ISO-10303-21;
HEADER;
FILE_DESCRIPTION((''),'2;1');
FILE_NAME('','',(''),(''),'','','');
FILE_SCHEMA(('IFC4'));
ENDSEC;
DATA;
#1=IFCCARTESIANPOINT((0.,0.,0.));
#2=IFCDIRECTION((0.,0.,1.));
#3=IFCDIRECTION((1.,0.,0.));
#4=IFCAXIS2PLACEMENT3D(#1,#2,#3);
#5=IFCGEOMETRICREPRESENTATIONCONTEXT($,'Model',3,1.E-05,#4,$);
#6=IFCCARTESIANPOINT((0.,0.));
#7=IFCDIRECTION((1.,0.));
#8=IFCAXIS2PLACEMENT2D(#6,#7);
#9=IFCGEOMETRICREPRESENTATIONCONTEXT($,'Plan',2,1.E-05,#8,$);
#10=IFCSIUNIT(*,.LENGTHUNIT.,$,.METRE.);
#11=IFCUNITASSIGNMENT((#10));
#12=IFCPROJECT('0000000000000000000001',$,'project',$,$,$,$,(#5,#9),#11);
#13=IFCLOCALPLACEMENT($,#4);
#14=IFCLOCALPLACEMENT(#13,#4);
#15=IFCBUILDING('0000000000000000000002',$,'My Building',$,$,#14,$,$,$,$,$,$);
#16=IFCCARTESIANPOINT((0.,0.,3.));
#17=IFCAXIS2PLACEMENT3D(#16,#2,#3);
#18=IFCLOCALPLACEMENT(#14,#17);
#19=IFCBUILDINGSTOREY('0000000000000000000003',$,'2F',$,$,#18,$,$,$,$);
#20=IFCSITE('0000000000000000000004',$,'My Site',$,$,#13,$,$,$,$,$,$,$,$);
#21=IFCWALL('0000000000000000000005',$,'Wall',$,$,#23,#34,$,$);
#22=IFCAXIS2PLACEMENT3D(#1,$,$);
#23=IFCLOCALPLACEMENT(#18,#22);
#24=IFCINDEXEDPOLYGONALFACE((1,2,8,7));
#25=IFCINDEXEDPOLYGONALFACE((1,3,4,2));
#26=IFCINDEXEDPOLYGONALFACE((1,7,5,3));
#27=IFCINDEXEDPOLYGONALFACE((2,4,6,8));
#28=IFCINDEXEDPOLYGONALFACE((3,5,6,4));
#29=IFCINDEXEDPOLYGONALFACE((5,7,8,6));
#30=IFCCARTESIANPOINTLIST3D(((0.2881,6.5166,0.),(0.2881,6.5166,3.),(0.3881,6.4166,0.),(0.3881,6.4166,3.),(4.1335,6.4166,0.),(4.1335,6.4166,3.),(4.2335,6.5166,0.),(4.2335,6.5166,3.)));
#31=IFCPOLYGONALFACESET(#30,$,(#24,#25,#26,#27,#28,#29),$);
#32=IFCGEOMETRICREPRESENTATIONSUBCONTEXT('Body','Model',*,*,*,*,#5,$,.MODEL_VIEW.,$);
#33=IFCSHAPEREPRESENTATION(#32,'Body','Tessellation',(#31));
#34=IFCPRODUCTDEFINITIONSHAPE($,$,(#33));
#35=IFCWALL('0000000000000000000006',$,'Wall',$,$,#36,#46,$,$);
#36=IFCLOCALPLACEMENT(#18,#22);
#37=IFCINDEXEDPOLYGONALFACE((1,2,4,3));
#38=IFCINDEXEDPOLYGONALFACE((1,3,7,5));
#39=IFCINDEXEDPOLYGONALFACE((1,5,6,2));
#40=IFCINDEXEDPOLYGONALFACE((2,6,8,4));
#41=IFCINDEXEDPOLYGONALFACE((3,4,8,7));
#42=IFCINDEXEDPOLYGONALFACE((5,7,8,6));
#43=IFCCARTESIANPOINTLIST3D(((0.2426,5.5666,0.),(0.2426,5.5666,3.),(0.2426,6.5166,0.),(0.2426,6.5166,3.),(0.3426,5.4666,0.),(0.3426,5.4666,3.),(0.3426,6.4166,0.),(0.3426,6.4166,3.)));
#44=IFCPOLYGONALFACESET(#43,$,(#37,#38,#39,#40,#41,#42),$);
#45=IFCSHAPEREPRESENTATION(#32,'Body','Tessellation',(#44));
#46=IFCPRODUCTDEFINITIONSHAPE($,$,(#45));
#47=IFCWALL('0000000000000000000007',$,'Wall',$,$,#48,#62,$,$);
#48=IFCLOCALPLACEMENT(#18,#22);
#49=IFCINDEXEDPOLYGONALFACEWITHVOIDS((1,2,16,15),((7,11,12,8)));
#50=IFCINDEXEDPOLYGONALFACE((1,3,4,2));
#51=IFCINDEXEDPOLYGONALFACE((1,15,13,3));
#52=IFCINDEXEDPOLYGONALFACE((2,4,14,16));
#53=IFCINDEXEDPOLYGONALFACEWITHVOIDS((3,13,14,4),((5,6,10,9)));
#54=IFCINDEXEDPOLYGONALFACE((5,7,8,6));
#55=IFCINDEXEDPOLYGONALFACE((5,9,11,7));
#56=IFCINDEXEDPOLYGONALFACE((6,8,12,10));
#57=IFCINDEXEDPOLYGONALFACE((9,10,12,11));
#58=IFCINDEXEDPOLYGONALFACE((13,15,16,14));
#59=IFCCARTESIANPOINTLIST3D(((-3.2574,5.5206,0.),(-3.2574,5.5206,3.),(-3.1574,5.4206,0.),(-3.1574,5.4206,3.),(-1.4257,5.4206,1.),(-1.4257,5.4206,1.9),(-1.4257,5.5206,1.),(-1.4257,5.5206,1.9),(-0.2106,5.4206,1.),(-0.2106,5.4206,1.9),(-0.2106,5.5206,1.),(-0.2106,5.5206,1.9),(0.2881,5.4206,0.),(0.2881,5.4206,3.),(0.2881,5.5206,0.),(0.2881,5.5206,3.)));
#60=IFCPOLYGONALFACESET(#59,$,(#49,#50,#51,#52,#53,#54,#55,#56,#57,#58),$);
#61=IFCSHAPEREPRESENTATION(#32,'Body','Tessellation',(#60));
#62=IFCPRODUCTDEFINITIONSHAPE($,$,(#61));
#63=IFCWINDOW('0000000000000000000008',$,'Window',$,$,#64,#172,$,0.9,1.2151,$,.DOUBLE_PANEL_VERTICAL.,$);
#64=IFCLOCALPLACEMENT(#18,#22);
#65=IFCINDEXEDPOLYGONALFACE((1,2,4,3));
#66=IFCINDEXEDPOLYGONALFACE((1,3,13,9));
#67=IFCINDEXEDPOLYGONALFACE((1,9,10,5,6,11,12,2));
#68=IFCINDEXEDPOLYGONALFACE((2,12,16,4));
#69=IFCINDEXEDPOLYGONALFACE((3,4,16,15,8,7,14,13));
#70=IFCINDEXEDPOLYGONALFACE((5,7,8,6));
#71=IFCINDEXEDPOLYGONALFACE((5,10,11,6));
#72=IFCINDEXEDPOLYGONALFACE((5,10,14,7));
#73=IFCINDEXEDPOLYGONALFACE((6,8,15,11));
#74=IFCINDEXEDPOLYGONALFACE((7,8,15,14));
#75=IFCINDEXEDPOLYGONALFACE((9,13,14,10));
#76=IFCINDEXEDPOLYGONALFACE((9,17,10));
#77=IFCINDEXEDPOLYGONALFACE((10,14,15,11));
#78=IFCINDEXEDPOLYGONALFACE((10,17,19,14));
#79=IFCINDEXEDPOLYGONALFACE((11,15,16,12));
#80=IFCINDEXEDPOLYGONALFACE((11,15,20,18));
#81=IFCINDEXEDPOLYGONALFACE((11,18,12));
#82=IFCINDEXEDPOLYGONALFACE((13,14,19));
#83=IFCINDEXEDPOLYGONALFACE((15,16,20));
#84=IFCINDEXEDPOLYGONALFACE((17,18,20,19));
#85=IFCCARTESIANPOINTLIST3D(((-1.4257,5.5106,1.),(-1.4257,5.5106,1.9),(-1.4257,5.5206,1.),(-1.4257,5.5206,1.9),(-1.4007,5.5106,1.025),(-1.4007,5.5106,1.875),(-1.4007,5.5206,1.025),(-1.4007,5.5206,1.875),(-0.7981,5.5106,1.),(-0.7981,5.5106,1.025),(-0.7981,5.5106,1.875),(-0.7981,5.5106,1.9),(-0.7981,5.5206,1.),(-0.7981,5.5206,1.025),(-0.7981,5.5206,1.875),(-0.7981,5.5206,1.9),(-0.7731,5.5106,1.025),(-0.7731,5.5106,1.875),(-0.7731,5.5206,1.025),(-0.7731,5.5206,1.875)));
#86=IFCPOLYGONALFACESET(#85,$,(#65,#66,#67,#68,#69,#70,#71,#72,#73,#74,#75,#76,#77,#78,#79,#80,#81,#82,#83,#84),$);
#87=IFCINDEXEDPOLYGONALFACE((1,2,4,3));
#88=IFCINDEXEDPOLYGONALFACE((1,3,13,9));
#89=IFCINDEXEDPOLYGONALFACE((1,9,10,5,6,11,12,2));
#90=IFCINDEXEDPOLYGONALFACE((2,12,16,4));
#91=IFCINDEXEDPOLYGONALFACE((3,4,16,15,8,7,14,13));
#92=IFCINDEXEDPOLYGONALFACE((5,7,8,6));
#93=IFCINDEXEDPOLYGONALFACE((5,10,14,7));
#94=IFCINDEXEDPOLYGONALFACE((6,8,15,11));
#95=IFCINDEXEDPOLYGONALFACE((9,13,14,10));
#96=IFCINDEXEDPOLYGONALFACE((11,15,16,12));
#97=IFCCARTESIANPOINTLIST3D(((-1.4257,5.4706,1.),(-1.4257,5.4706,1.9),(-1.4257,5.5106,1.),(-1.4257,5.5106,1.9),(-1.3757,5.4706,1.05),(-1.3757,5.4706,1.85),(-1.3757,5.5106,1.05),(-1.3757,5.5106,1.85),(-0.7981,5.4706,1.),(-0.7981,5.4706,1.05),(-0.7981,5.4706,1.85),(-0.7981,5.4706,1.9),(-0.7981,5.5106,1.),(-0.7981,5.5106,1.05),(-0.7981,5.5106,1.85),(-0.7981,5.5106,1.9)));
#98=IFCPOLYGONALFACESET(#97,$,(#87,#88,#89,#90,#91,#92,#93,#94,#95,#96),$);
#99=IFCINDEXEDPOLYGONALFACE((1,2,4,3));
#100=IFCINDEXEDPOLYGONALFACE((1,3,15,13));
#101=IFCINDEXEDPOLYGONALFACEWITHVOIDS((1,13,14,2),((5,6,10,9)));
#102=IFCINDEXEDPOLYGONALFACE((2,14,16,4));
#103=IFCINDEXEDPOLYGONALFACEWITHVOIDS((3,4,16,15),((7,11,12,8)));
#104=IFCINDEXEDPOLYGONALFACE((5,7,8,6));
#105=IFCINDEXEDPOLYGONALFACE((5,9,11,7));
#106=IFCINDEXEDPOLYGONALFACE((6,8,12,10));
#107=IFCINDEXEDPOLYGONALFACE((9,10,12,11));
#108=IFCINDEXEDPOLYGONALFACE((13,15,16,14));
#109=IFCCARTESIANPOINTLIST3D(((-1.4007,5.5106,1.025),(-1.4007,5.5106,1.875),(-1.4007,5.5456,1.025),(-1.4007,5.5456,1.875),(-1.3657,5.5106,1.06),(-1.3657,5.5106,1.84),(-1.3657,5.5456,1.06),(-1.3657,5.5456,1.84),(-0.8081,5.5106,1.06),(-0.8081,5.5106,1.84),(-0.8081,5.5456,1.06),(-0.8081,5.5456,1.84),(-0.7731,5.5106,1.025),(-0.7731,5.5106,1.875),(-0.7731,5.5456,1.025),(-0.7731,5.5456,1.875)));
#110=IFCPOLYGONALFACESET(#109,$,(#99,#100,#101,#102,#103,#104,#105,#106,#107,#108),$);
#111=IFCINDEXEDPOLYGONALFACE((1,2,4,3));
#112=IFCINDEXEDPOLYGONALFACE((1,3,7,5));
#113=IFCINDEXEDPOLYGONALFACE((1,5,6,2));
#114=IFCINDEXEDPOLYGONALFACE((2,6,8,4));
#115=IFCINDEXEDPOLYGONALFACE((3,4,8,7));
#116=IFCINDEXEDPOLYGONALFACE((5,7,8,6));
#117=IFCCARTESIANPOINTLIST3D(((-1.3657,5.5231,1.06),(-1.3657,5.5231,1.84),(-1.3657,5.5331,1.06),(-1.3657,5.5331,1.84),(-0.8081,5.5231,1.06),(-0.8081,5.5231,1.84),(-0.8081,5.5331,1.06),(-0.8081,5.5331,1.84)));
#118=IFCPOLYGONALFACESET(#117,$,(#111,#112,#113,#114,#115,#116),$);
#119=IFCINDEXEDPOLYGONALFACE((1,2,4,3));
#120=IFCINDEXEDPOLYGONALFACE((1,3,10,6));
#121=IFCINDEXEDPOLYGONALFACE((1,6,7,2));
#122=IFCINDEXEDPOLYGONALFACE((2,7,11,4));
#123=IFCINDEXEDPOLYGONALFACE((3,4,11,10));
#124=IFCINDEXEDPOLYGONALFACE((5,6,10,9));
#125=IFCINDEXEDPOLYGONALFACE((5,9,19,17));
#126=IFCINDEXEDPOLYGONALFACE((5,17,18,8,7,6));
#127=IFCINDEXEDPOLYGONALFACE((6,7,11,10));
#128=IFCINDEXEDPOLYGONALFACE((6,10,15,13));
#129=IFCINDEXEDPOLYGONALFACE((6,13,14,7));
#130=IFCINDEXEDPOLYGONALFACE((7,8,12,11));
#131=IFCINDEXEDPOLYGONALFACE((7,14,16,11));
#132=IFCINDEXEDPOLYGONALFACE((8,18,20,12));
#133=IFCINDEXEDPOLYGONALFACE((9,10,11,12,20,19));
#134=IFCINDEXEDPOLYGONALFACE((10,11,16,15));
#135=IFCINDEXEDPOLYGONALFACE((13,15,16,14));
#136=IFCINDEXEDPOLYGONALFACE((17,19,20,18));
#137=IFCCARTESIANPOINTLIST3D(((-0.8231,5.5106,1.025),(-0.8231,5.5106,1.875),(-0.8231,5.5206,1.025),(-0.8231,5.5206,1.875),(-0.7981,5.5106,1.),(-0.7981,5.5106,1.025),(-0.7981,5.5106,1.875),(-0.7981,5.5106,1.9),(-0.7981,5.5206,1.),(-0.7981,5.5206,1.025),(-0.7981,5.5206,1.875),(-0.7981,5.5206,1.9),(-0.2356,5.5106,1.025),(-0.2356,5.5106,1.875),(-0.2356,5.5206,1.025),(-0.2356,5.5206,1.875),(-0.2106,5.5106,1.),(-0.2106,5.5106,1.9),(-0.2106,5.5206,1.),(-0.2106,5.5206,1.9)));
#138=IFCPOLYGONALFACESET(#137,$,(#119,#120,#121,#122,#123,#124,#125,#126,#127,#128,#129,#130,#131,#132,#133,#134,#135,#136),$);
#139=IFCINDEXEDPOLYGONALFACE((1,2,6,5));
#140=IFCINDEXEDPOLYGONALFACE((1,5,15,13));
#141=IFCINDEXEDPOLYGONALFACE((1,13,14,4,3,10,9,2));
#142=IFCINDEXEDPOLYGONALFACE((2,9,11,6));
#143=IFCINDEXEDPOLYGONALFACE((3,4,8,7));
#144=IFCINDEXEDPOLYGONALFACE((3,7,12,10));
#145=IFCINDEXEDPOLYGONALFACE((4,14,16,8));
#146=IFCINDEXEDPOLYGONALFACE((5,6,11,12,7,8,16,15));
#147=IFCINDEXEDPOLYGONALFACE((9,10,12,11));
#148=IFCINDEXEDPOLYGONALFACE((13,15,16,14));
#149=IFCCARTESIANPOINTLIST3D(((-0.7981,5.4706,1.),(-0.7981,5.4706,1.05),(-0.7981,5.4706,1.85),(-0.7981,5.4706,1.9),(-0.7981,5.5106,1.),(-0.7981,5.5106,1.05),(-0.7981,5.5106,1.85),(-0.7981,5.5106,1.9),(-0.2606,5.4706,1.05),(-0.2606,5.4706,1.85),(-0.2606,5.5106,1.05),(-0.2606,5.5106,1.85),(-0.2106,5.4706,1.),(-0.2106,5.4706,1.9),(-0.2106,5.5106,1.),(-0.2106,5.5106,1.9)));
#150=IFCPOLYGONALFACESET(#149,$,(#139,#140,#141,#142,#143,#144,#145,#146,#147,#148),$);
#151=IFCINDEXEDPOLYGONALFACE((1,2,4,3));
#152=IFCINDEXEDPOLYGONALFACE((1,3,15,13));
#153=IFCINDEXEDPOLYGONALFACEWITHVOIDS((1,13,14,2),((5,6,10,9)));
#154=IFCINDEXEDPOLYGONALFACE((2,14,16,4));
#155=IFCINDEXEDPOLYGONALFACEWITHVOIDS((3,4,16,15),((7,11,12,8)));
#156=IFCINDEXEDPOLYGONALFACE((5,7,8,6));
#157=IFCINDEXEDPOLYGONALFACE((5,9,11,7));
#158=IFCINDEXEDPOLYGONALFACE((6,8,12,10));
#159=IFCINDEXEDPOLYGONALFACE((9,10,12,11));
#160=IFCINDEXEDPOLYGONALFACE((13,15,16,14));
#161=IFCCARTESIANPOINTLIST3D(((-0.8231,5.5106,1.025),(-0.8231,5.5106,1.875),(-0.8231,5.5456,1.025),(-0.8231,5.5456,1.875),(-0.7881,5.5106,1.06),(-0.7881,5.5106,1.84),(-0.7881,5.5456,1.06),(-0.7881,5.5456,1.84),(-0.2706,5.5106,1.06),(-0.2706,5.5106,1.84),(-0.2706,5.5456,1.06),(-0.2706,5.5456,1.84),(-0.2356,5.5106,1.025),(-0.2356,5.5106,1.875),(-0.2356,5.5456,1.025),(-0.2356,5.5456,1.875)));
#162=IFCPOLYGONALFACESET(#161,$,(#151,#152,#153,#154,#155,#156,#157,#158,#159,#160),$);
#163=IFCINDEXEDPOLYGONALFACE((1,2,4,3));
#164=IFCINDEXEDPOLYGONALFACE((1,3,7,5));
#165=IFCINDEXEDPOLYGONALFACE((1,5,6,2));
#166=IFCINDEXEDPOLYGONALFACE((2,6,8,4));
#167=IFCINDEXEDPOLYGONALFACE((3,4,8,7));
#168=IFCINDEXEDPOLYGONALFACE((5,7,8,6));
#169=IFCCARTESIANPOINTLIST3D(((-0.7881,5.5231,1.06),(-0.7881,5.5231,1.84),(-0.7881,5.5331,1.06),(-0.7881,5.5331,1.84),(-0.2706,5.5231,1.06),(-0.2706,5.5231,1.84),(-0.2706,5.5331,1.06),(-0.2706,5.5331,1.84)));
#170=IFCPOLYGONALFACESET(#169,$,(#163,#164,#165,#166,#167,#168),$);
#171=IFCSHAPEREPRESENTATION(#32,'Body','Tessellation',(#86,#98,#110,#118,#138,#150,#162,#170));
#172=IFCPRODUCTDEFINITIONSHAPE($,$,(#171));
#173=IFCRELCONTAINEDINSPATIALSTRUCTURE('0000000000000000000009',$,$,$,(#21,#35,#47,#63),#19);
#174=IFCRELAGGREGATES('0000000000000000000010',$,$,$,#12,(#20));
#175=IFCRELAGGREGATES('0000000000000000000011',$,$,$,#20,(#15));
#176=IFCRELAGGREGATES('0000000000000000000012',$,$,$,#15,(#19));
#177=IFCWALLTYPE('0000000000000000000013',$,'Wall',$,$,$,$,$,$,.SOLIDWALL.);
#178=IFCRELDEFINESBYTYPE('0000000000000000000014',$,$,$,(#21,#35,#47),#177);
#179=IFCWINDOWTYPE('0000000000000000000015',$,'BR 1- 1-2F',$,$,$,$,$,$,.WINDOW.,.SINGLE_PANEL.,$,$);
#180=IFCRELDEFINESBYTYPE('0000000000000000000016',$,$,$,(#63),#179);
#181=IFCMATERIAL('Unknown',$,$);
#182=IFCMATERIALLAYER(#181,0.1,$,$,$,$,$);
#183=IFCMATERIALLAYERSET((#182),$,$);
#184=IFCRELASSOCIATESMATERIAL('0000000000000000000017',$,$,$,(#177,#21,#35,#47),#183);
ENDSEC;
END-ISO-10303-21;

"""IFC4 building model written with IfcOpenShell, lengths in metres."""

from ifc_helpers import new_model, entity, si_unit, frame, origin_with_axes, origin_2d_with_axis, place, context, subcontext, project, spatial, line, indexed_curve, outline, extrude, shape, source, transform, mapped, material, layer, layer_set, layer_usage, type_object, type_shapes, element, fill, save


model = new_model("IFC4")

# Units and contexts
model_context = context("Model", 3, precision=1e-05, world=origin_with_axes())
plan_context = context("Plan", 2, precision=1e-05, world=origin_2d_with_axis())
body_context_1 = subcontext(model_context, "Body", "Model", "MODEL_VIEW")
body_context_2 = subcontext(plan_context, "Body", "Plan", "PLAN_VIEW")
ifc_project = project(units=[si_unit("LENGTHUNIT", "METRE")], contexts=[model_context, plan_context])

# Site, building, storey
site_placement = place(None, origin_with_axes())
site = spatial("IfcSite", under=ifc_project, at=site_placement, Name="My Site")
building_placement = place(site_placement, origin_with_axes())
building = spatial("IfcBuilding", under=site, at=building_placement, Name="My Building")
storey_placement = place(building_placement, frame((0.0, 0.0, 3.0), z_axis=(0.0, 0.0, 1.0), x_axis=(1.0, 0.0, 0.0)))
storey = spatial("IfcBuildingStorey", under=building, at=storey_placement, Name="2F")

# Walls
ifc_material = material(Name="Unknown")
ifc_layer = layer(ifc_material, 0.1)
ifc_layer_set = layer_set([ifc_layer])
ifc_layer_usage_1 = layer_usage(ifc_layer_set, "AXIS2", "POSITIVE", 0.0)
wall_type = type_object("IfcWallType", Name="Wall", PredefinedType="SOLIDWALL", material=ifc_layer_set)
wall_1_placement = place(storey_placement, frame((4.2335, 6.5166, 0.0), z_axis=(0.0, 0.0, 1.0), x_axis=(-1.0, 0.0, 0.0)))
element("IfcWall", 1, at=wall_1_placement, inside=storey, type_object=wall_type, material=ifc_layer_usage_1, Name="Wall", context=body_context_1, shape_type="SweptSolid", body=[
    extrude(outline(indexed_curve([(0.0, 0.0), (0.1, 0.1), (3.8454, 0.1), (3.9454, 0.0)], segments=[line(1, 2, 3, 4, 1)])), origin_with_axes(), (0.0, 0.0, 1.0), 3.0),
])
ifc_layer_usage_2 = layer_usage(ifc_layer_set, "AXIS2", "POSITIVE", 0.0)
wall_2_placement = place(storey_placement, frame((0.2426, 6.5166, 0.0), z_axis=(0.0, 0.0, 1.0), x_axis=(0.0, -1.0, 0.0)))
element("IfcWall", 2, at=wall_2_placement, inside=storey, type_object=wall_type, material=ifc_layer_usage_2, Name="Wall", context=body_context_1, shape_type="SweptSolid", body=[
    extrude(outline(indexed_curve([(0.0, 0.0), (0.1, 0.1), (1.05, 0.1), (0.95, 0.0)], segments=[line(1, 2, 3, 4, 1)])), origin_with_axes(), (0.0, 0.0, 1.0), 3.0),
])

# Wall, opening, window
ifc_layer_usage_3 = layer_usage(ifc_layer_set, "AXIS2", "POSITIVE", 0.0)
wall_3_placement = place(storey_placement, frame((0.3881, 5.5206, 0.0), z_axis=(0.0, 0.0, 1.0), x_axis=(-1.0, 0.0, 0.0)))
wall_3 = element("IfcWall", 3, at=wall_3_placement, inside=storey, type_object=wall_type, material=ifc_layer_usage_3, Name="Wall", context=body_context_1, shape_type="SweptSolid", body=[
    extrude(outline(indexed_curve([(0.1, 0.0), (0.1, 0.1), (3.5455, 0.1), (3.6455, 0.0)], segments=[line(1, 2, 3, 4, 1)])), origin_with_axes(), (0.0, 0.0, 1.0), 3.0),
])
shared_shape_1 = source(origin_with_axes(), body_context_1, "Body", "SweptSolid", [
    extrude(outline(indexed_curve([(0.0, 0.0), (1.2151, 0.0), (1.2151, 0.9), (0.0, 0.9)], segments=[line(1, 2, 3, 4, 1)])), frame((0.0, -0.6, 0.0), z_axis=(0.0, -1.0, 0.0), x_axis=(1.0, 0.0, 0.0)), (0.0, 0.0, -1.0), 1.2),
])
opening_1_placement = place(wall_3_placement, frame((1.8138, 0.1, 1.0), z_axis=(0.0, 0.0, 1.0), x_axis=(-1.0, 0.0, 0.0)))
opening_1 = element("IfcOpeningElement", 4, at=opening_1_placement, cuts=wall_3, PredefinedType="OPENING", context=body_context_1, shape_type="MappedRepresentation", body=[
    mapped(shared_shape_1, transform((0.0, 0.0, 0.0), x_axis=(1.0, 0.0, 0.0), y_axis=(0.0, 1.0, 0.0), z_axis=(0.0, 0.0, 1.0), scale=1.0)),
])
window_type_1 = type_object("IfcWindowType", Name="BR 1- 1-2F", PartitioningType="SINGLE_PANEL", PredefinedType="WINDOW")
shared_shape_2 = source(origin_with_axes(), body_context_1, "Body", "SweptSolid", [
    extrude(outline(indexed_curve([(0.0, 0.0), (0.6275, 0.0), (0.6275, 0.9), (0.0, 0.9)], segments=[line(1, 2, 3, 4, 1)]), holes=[indexed_curve([(0.025, 0.025), (0.6525, 0.025), (0.6525, 0.875), (0.025, 0.875)], segments=[line(1, 2, 3, 4, 1)])]), frame((0.0, 0.09, 0.0), z_axis=(0.0, -1.0, 0.0), x_axis=(1.0, 0.0, 0.0)), (0.0, 0.0, -1.0), 0.01),
    extrude(outline(indexed_curve([(0.6275, 0.0), (0.0, 0.0), (0.0, 0.9), (0.6275, 0.9), (0.6275, 0.85), (0.05, 0.85), (0.05, 0.05), (0.6275, 0.05)], segments=[line(1, 2, 3, 4, 5, 6, 7, 8, 1)])), frame((0.0, 0.05, 0.0), z_axis=(0.0, -1.0, 0.0), x_axis=(1.0, 0.0, 0.0)), (0.0, 0.0, -1.0), 0.04),
    extrude(outline(indexed_curve([(0.0, 0.0), (0.6275, 0.0), (0.6275, 0.85), (0.0, 0.85)], segments=[line(1, 2, 3, 4, 1)]), holes=[indexed_curve([(0.035, 0.035), (0.5925, 0.035), (0.5925, 0.815), (0.035, 0.815)], segments=[line(1, 2, 3, 4, 1)])]), frame((0.025, 0.09, 0.025), z_axis=(0.0, -1.0, 0.0), x_axis=(1.0, 0.0, 0.0)), (0.0, 0.0, -1.0), 0.035),
    extrude(outline(indexed_curve([(0.035, 0.035), (0.5925, 0.035), (0.5925, 0.815), (0.035, 0.815)], segments=[line(1, 2, 3, 4, 1)])), frame((0.025, 0.1025, 0.025), z_axis=(0.0, -1.0, 0.0), x_axis=(1.0, 0.0, 0.0)), (0.0, 0.0, -1.0), 0.01),
    extrude(outline(indexed_curve([(0.0, 0.0), (0.5875, 0.0), (0.5875, 0.9), (0.0, 0.9)], segments=[line(1, 2, 3, 4, 1)]), holes=[indexed_curve([(-0.025, 0.025), (0.5625, 0.025), (0.5625, 0.875), (-0.025, 0.875)], segments=[line(1, 2, 3, 4, 1)])]), frame((0.6275, 0.09, 0.0), z_axis=(0.0, -1.0, 0.0), x_axis=(1.0, 0.0, 0.0)), (0.0, 0.0, -1.0), 0.01),
    extrude(outline(indexed_curve([(0.0, 0.9), (0.5875, 0.9), (0.5875, 0.0), (0.0, 0.0), (0.0, 0.05), (0.5375, 0.05), (0.5375, 0.85), (0.0, 0.85)], segments=[line(1, 2, 3, 4, 5, 6, 7, 8, 1)])), frame((0.6275, 0.05, 0.0), z_axis=(0.0, -1.0, 0.0), x_axis=(1.0, 0.0, 0.0)), (0.0, 0.0, -1.0), 0.04),
    extrude(outline(indexed_curve([(0.0, 0.0), (0.5875, 0.0), (0.5875, 0.85), (0.0, 0.85)], segments=[line(1, 2, 3, 4, 1)]), holes=[indexed_curve([(0.035, 0.035), (0.5525, 0.035), (0.5525, 0.815), (0.035, 0.815)], segments=[line(1, 2, 3, 4, 1)])]), frame((0.6025, 0.09, 0.025), z_axis=(0.0, -1.0, 0.0), x_axis=(1.0, 0.0, 0.0)), (0.0, 0.0, -1.0), 0.035),
    extrude(outline(indexed_curve([(0.035, 0.035), (0.5525, 0.035), (0.5525, 0.815), (0.035, 0.815)], segments=[line(1, 2, 3, 4, 1)])), frame((0.6025, 0.1025, 0.025), z_axis=(0.0, -1.0, 0.0), x_axis=(1.0, 0.0, 0.0)), (0.0, 0.0, -1.0), 0.01),
])
shared_shape_3 = source(origin_with_axes(), body_context_2, "Body", "Curve2D", [
    entity("IfcIndexedPolyCurve", entity("IfcCartesianPointList2D", [[0.05, 0.05], [0.6275, 0.05]])),
    entity("IfcIndexedPolyCurve", entity("IfcCartesianPointList2D", [[0.0, 0.1], [0.025, 0.1], [0.025, 0.09], [0.05, 0.09], [0.05, 0.05], [0.0, 0.05]]), [entity("IfcLineIndex", [1, 2, 3, 4, 5, 6, 1])]),
    entity("IfcIndexedPolyCurve", entity("IfcCartesianPointList2D", [[0.6275, 0.1], [0.6525, 0.1], [0.6525, 0.09], [0.6275, 0.09], [0.6275, 0.05], [0.6275, 0.05]])),
    entity("IfcIndexedPolyCurve", entity("IfcCartesianPointList2D", [[0.025, 0.09], [0.06, 0.09], [0.06, 0.125], [0.025, 0.125]]), [entity("IfcLineIndex", [1, 2, 3, 4, 1])]),
    entity("IfcIndexedPolyCurve", entity("IfcCartesianPointList2D", [[0.6525, 0.09], [0.6175, 0.09], [0.6175, 0.125], [0.6525, 0.125]]), [entity("IfcLineIndex", [1, 2, 3, 4, 1])]),
    entity("IfcIndexedPolyCurve", entity("IfcCartesianPointList2D", [[0.06, 0.09], [0.6175, 0.09]])),
    entity("IfcIndexedPolyCurve", entity("IfcCartesianPointList2D", [[0.06, 0.125], [0.6175, 0.125]])),
    entity("IfcIndexedPolyCurve", entity("IfcCartesianPointList2D", [[0.06, 0.1075], [0.6175, 0.1075]])),
    entity("IfcIndexedPolyCurve", entity("IfcCartesianPointList2D", [[0.6275, 0.05], [1.1651, 0.05]])),
    entity("IfcIndexedPolyCurve", entity("IfcCartesianPointList2D", [[0.6275, 0.1], [0.6025, 0.1], [0.6025, 0.09], [0.6275, 0.09], [0.6275, 0.05], [0.6275, 0.05]])),
    entity("IfcIndexedPolyCurve", entity("IfcCartesianPointList2D", [[1.2151, 0.1], [1.1901, 0.1], [1.1901, 0.09], [1.1651, 0.09], [1.1651, 0.05], [1.2151, 0.05]]), [entity("IfcLineIndex", [1, 2, 3, 4, 5, 6, 1])]),
    entity("IfcIndexedPolyCurve", entity("IfcCartesianPointList2D", [[0.6025, 0.09], [0.6375, 0.09], [0.6375, 0.125], [0.6025, 0.125]]), [entity("IfcLineIndex", [1, 2, 3, 4, 1])]),
    entity("IfcIndexedPolyCurve", entity("IfcCartesianPointList2D", [[1.1901, 0.09], [1.1551, 0.09], [1.1551, 0.125], [1.1901, 0.125]]), [entity("IfcLineIndex", [1, 2, 3, 4, 1])]),
    entity("IfcIndexedPolyCurve", entity("IfcCartesianPointList2D", [[0.6375, 0.09], [1.1551, 0.09]])),
    entity("IfcIndexedPolyCurve", entity("IfcCartesianPointList2D", [[0.6375, 0.125], [1.1551, 0.125]])),
    entity("IfcIndexedPolyCurve", entity("IfcCartesianPointList2D", [[0.6375, 0.1075], [1.1551, 0.1075]])),
])
type_shapes(window_type_1, [shared_shape_2, shared_shape_3])
window_1_placement = place(opening_1_placement, frame((0.0, 0.0, 0.0), z_axis=(0.0, 0.0, 1.0), x_axis=(1.0, 0.0, 0.0)))
window_1 = element("IfcWindow", 5, at=window_1_placement, inside=storey, type_object=window_type_1, Name="Window", OverallHeight=0.9, OverallWidth=1.2151, PartitioningType="DOUBLE_PANEL_VERTICAL", shapes=[
    shape(body_context_1, "Body", "MappedRepresentation", [mapped(shared_shape_2, transform((0.0, 0.0, 0.0), x_axis=(1.0, 0.0, 0.0), y_axis=(0.0, 1.0, 0.0), z_axis=(0.0, 0.0, 1.0), scale=1.0))]),
    shape(body_context_2, "Body", "MappedRepresentation", [mapped(shared_shape_3, transform((0.0, 0.0, 0.0), x_axis=(1.0, 0.0, 0.0), y_axis=(0.0, 1.0, 0.0), z_axis=(0.0, 0.0, 1.0), scale=1.0))]),
])
fill(opening_1, window_1)

save(model, "model.ifc")
